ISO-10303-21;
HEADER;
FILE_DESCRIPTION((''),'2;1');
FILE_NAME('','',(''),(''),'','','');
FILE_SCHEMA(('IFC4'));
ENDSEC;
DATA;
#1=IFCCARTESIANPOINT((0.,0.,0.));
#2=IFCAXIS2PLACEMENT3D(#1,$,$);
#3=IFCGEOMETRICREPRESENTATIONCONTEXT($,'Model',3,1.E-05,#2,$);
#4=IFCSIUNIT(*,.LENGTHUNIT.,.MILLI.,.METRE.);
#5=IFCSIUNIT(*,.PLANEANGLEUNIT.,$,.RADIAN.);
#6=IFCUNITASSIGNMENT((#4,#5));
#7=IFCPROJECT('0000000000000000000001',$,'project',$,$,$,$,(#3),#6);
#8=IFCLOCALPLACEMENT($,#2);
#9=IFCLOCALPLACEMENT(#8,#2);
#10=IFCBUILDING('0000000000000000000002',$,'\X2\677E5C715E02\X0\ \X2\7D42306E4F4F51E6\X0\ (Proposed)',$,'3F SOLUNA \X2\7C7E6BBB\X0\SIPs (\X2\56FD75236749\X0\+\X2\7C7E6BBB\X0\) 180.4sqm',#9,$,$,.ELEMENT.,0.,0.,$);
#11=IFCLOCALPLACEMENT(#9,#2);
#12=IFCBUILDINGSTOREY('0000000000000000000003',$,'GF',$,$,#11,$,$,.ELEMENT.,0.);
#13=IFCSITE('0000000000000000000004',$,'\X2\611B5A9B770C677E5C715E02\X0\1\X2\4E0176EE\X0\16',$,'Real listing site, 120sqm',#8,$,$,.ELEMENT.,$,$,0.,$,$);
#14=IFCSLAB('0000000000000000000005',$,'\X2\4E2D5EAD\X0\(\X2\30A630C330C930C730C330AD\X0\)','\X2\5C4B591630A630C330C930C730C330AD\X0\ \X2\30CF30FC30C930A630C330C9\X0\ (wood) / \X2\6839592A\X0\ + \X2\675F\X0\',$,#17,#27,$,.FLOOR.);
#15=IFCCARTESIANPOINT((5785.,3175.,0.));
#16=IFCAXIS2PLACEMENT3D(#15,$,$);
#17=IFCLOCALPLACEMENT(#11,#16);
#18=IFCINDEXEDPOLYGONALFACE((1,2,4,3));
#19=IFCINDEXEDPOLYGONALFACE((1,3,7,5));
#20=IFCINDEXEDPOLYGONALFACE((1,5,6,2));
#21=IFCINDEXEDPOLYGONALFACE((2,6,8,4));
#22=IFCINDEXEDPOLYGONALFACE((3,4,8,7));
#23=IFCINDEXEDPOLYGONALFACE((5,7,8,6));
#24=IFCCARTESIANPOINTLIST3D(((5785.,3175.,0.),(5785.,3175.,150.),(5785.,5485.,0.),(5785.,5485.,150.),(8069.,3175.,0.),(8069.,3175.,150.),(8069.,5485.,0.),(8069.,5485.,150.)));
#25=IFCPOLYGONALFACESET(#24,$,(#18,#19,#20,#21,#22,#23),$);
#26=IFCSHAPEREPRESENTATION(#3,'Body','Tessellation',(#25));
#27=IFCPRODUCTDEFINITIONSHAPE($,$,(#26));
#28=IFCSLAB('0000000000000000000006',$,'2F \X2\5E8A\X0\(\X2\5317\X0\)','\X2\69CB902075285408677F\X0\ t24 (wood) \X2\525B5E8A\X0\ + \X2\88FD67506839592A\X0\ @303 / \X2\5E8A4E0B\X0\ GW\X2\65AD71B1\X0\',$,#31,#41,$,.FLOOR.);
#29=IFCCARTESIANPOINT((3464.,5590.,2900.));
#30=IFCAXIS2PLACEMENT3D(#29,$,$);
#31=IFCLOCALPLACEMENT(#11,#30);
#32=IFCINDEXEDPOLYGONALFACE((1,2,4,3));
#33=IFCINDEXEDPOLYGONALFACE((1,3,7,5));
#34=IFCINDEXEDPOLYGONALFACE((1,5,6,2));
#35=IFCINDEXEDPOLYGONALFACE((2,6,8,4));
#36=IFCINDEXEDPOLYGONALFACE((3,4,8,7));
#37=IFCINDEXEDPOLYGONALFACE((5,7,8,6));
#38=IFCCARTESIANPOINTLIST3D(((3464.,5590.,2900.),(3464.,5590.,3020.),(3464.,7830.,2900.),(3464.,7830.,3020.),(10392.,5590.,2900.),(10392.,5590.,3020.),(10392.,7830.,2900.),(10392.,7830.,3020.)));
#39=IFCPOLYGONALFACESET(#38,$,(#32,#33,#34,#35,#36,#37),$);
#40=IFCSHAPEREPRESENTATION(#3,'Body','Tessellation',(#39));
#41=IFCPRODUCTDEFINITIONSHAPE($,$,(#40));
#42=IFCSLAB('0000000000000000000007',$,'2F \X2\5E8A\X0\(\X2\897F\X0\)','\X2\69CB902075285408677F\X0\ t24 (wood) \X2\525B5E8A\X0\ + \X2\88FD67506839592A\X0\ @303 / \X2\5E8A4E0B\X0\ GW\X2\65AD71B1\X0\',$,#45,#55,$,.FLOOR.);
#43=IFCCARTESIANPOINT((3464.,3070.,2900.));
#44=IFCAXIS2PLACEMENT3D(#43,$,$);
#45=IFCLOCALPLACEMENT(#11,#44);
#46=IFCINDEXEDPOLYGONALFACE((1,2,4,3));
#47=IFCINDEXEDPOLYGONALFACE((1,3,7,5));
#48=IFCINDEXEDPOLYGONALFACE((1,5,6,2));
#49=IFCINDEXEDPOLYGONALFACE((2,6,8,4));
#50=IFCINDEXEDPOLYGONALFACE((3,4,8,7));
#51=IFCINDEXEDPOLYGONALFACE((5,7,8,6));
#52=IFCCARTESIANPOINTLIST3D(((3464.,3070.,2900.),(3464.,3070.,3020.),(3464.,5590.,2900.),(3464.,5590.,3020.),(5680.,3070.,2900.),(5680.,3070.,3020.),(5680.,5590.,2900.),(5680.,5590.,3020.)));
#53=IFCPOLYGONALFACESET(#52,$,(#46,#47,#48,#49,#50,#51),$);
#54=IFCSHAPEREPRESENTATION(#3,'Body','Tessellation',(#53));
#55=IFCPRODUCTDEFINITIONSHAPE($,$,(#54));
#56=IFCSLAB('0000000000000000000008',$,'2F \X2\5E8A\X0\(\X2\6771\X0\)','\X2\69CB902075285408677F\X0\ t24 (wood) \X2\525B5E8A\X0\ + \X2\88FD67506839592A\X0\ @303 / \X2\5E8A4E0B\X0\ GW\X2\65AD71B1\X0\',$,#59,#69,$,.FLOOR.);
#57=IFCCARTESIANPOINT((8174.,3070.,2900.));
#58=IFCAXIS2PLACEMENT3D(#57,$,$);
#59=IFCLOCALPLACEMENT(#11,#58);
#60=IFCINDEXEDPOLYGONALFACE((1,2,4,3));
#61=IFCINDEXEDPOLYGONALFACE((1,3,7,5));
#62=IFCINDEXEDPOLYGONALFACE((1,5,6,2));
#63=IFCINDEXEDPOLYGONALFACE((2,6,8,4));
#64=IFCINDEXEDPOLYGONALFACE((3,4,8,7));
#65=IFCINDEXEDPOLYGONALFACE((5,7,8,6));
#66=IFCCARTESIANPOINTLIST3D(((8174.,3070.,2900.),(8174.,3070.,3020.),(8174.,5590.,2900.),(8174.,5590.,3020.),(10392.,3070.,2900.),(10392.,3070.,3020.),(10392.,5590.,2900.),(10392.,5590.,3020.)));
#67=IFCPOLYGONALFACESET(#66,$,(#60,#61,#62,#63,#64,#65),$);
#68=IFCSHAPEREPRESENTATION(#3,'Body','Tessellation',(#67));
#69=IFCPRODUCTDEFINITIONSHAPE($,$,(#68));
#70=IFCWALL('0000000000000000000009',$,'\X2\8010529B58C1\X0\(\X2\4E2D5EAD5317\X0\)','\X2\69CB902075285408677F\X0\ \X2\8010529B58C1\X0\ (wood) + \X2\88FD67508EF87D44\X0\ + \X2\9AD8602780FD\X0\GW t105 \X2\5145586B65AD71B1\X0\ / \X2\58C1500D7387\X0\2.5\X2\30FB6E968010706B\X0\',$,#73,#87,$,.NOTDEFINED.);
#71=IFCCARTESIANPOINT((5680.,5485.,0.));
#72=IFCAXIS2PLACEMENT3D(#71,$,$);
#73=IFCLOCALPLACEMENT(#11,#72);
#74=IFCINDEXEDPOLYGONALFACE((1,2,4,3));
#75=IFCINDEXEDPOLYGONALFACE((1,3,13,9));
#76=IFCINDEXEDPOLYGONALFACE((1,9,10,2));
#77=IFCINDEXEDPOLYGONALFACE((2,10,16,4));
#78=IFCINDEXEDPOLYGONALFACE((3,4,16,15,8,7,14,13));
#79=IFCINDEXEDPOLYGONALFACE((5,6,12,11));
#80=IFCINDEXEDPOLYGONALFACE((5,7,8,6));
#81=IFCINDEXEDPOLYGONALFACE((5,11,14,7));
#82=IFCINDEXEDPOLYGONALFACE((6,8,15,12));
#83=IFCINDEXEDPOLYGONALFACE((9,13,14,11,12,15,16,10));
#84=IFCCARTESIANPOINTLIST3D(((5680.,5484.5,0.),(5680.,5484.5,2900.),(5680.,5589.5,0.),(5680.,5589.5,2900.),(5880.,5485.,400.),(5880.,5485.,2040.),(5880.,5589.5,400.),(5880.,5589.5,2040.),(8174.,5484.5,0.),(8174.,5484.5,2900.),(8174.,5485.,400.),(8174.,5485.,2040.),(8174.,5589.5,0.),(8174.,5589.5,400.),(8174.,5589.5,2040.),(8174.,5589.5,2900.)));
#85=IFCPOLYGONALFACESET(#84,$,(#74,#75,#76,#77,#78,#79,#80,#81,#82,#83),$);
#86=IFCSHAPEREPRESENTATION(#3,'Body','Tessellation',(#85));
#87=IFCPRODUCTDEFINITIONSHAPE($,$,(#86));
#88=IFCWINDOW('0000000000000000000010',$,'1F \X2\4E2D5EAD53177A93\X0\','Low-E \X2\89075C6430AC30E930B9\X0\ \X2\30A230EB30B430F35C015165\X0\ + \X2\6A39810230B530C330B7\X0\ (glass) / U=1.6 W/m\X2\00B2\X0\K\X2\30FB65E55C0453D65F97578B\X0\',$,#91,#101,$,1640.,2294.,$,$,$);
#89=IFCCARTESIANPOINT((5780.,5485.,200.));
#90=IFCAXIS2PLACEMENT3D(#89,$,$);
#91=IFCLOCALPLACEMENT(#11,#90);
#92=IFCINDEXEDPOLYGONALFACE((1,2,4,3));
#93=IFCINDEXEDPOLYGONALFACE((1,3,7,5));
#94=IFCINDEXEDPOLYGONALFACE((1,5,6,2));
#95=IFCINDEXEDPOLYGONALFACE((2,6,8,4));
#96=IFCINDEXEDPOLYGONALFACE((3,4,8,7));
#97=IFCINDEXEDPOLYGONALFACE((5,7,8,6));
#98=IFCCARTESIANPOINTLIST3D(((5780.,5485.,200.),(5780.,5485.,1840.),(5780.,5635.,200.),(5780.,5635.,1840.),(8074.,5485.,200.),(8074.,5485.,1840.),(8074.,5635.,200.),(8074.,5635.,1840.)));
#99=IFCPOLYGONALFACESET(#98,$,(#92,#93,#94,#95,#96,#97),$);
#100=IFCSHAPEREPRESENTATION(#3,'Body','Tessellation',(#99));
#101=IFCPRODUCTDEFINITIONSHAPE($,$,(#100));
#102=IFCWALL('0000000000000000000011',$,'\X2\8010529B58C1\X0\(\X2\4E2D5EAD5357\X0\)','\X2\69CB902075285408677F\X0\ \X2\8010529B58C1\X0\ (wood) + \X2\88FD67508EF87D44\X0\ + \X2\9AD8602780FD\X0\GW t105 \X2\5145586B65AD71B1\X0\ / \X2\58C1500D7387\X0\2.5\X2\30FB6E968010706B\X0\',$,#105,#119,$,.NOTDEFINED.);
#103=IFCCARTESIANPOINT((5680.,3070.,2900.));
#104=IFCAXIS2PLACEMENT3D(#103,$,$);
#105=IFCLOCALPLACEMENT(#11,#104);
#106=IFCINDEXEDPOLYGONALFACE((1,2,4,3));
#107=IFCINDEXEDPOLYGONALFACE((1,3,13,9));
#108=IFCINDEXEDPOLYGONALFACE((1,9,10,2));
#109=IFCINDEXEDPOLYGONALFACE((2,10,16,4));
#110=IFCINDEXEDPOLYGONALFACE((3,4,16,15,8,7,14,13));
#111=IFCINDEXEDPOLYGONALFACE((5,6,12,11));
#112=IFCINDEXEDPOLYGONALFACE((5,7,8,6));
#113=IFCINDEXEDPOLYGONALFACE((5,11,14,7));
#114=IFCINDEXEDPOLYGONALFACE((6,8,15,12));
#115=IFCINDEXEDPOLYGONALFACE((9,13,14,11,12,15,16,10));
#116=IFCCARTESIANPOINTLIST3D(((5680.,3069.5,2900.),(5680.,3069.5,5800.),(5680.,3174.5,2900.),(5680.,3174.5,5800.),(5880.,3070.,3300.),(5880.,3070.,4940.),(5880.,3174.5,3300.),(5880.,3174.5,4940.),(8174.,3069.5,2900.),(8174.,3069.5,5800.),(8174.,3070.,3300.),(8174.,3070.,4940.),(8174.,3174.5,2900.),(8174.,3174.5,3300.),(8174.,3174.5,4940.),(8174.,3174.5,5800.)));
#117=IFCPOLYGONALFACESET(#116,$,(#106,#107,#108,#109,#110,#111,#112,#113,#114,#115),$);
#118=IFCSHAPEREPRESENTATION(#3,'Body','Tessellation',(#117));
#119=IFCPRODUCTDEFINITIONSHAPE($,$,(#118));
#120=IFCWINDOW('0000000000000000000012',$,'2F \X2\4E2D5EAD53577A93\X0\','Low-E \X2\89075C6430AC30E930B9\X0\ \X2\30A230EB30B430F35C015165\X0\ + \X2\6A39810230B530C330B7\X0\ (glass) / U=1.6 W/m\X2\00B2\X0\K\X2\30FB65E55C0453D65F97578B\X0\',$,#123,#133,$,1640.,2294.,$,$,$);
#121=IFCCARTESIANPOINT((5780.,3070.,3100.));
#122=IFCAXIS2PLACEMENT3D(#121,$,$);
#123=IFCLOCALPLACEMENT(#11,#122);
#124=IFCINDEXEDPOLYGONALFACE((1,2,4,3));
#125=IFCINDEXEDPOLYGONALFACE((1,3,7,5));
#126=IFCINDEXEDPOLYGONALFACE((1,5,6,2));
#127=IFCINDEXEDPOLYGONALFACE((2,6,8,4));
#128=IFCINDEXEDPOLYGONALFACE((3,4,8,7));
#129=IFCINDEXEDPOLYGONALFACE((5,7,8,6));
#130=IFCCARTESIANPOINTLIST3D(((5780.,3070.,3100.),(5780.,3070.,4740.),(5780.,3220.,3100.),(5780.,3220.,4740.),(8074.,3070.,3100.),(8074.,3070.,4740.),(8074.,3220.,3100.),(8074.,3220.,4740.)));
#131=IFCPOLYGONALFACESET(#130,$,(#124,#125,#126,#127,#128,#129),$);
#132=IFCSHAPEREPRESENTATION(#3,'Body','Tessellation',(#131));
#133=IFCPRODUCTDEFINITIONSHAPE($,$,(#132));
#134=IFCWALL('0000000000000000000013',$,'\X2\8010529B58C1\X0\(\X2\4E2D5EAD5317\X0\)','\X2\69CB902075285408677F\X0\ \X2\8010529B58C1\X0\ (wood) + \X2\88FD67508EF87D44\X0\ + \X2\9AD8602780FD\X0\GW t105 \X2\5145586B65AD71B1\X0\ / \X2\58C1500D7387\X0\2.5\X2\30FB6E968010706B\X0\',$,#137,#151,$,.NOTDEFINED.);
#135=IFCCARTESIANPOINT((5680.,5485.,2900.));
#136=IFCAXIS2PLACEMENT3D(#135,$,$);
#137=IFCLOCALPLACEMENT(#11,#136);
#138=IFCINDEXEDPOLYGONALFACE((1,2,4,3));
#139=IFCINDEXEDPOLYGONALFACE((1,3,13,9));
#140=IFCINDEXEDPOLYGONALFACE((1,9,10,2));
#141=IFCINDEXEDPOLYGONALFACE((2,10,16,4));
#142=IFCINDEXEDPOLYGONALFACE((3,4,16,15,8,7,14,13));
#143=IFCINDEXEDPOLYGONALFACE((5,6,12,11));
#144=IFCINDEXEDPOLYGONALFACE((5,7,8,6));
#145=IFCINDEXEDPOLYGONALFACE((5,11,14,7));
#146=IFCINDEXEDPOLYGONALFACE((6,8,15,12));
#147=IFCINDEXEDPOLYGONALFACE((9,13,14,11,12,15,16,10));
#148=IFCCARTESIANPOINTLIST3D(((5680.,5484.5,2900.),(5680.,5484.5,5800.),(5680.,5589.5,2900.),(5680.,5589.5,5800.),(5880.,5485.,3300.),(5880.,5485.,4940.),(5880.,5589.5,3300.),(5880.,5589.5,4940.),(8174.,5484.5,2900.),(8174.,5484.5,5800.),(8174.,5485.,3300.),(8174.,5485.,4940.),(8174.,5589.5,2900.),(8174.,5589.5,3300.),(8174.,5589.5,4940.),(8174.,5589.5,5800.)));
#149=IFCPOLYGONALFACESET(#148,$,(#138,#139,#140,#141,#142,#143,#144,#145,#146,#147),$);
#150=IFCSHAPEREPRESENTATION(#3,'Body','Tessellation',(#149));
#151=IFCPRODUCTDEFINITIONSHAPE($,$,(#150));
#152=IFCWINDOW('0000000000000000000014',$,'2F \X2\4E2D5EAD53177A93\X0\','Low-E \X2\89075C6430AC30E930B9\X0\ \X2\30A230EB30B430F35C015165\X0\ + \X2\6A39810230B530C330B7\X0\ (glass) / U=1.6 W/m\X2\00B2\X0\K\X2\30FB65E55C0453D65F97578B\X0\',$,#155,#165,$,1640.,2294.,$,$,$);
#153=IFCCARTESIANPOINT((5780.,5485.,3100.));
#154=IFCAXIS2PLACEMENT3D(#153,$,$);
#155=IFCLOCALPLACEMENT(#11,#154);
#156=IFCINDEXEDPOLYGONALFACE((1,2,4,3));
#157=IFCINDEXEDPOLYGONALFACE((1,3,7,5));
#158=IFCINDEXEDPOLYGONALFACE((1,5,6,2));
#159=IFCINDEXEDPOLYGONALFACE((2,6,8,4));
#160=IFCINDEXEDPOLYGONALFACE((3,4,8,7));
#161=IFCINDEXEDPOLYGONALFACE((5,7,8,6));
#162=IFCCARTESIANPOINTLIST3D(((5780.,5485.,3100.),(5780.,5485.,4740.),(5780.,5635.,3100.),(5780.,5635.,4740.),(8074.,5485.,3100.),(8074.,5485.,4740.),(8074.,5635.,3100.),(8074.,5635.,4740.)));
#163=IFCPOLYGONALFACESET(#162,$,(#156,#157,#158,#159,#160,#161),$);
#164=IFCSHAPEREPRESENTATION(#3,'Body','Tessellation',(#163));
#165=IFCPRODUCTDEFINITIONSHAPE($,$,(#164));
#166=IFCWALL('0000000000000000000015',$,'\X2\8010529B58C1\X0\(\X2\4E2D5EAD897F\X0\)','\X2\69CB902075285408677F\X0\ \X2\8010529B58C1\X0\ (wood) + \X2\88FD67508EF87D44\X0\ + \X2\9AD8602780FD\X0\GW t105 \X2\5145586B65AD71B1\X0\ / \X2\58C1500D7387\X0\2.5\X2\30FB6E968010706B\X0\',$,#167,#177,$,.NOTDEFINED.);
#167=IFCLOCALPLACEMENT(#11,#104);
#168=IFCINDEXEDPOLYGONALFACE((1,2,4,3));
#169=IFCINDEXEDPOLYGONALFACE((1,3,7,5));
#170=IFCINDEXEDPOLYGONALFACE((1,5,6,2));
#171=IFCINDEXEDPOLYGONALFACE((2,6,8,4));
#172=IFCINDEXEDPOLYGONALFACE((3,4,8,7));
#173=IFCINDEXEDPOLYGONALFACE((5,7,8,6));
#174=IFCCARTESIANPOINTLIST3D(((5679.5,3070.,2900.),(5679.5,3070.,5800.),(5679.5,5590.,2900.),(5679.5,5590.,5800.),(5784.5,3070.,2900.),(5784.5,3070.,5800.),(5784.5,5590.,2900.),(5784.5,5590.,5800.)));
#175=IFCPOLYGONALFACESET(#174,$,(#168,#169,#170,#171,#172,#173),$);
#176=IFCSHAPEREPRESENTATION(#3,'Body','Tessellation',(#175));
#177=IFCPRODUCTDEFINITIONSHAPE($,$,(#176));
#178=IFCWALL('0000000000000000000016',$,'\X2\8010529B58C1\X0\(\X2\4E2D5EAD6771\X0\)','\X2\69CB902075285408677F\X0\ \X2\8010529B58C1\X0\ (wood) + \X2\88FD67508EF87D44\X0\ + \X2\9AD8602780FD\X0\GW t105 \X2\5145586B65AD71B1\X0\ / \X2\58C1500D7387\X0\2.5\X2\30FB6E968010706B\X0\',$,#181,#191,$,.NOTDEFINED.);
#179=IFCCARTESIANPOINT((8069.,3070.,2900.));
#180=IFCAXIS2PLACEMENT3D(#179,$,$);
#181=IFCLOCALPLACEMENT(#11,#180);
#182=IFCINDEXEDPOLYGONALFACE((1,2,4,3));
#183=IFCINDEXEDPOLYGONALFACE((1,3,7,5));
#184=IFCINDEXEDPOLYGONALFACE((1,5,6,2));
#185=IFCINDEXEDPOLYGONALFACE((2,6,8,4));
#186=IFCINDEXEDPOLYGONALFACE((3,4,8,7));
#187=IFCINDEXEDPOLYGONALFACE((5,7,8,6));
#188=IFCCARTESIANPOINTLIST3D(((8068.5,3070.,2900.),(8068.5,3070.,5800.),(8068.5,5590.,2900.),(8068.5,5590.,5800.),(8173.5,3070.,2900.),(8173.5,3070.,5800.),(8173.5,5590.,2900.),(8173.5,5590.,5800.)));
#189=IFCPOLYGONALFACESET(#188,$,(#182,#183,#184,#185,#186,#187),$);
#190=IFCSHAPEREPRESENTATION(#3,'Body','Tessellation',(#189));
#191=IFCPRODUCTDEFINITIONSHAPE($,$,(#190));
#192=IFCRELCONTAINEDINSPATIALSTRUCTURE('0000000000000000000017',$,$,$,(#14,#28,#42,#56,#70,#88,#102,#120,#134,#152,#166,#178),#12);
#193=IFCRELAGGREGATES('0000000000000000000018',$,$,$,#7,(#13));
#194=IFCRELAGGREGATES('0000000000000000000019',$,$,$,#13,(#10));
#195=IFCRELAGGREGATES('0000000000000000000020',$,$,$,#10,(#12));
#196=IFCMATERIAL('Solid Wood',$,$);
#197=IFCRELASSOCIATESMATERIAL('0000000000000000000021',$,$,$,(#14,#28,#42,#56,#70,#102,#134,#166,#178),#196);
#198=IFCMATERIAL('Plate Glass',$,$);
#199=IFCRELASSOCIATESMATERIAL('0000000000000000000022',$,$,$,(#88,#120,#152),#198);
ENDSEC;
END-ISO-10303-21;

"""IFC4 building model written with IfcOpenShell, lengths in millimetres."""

from ifc_helpers import new_model, si_unit, frame, frame_2d, origin, place, context, project, spatial, rectangle, extrude, material, element, fill, save


model = new_model("IFC4")

# Units and contexts
model_context = context("Model", 3, precision=1e-05, world=origin())
ifc_project = project(units=[si_unit("LENGTHUNIT", "METRE", prefix="MILLI"), si_unit("PLANEANGLEUNIT", "RADIAN")], contexts=[model_context])

# Site, building, storey
site_placement = place(None, origin())
site = spatial("IfcSite", under=ifc_project, at=site_placement, Name="愛媛県松山市1丁目16", ObjectType="Real listing site, 120sqm", CompositionType="ELEMENT", RefElevation=0.0)
building_placement = place(site_placement, origin())
building = spatial("IfcBuilding", under=site, at=building_placement, Name="松山市 終の住処 (Proposed)", ObjectType="3F SOLUNA 籾殻SIPs (国産杉+籾殻) 180.4sqm", CompositionType="ELEMENT", ElevationOfRefHeight=0.0, ElevationOfTerrain=0.0)
storey_placement = place(building_placement, origin())
storey = spatial("IfcBuildingStorey", under=building, at=storey_placement, Name="GF", CompositionType="ELEMENT", Elevation=0.0)

# Slabs
ifc_material_1 = material(Name="Solid Wood")
slab_1_placement = place(storey_placement, frame((5785.0, 3175.0, 0.0)))
element("IfcSlab", 1, at=slab_1_placement, inside=storey, material=ifc_material_1, Name="中庭(ウッドデッキ)", Description="屋外ウッドデッキ ハードウッド (wood) / 根太 + 束", PredefinedType="FLOOR", context=model_context, shape_type="SweptSolid", body=[
    extrude(rectangle(XDim=2284.0, YDim=2310.0, at=frame_2d((1142.0, 1155.0))), frame((5785.0, 3175.0, 0.0)), (0.0, 0.0, 1.0), 150.0),
])
slab_2_placement = place(storey_placement, frame((3464.0, 5590.0, 2900.0)))
element("IfcSlab", 2, at=slab_2_placement, inside=storey, material=ifc_material_1, Name="2F 床(北)", Description="構造用合板 t24 (wood) 剛床 + 製材根太 @303 / 床下 GW断熱", PredefinedType="FLOOR", context=model_context, shape_type="SweptSolid", body=[
    extrude(rectangle(XDim=6928.0, YDim=2240.0, at=frame_2d((3464.0, 1120.0))), frame((3464.0, 5590.0, 2900.0)), (0.0, 0.0, 1.0), 120.0),
])
slab_3_placement = place(storey_placement, frame((3464.0, 3070.0, 2900.0)))
element("IfcSlab", 3, at=slab_3_placement, inside=storey, material=ifc_material_1, Name="2F 床(西)", Description="構造用合板 t24 (wood) 剛床 + 製材根太 @303 / 床下 GW断熱", PredefinedType="FLOOR", context=model_context, shape_type="SweptSolid", body=[
    extrude(rectangle(XDim=2216.0, YDim=2520.0, at=frame_2d((1108.0, 1260.0))), frame((3464.0, 3070.0, 2900.0)), (0.0, 0.0, 1.0), 120.0),
])
slab_4_placement = place(storey_placement, frame((8174.0, 3070.0, 2900.0)))
element("IfcSlab", 4, at=slab_4_placement, inside=storey, material=ifc_material_1, Name="2F 床(東)", Description="構造用合板 t24 (wood) 剛床 + 製材根太 @303 / 床下 GW断熱", PredefinedType="FLOOR", context=model_context, shape_type="SweptSolid", body=[
    extrude(rectangle(XDim=2218.0, YDim=2520.0, at=frame_2d((1109.0, 1260.0))), frame((8174.0, 3070.0, 2900.0)), (0.0, 0.0, 1.0), 120.0),
])

# Wall, opening, window
wall_1_placement = place(storey_placement, frame((5680.0, 5485.0, 0.0)))
wall_1 = element("IfcWall", 5, at=wall_1_placement, inside=storey, material=ifc_material_1, Name="耐力壁(中庭北)", Description="構造用合板 耐力壁 (wood) + 製材軸組 + 高性能GW t105 充填断熱 / 壁倍率2.5・準耐火", PredefinedType="NOTDEFINED", context=model_context, shape_type="SweptSolid", body=[
    extrude(rectangle(XDim=2494.0, YDim=105.0, at=frame_2d((1247.0, 52.0))), frame((5680.0, 5485.0, 0.0)), (0.0, 0.0, 1.0), 2900.0),
])
opening_1_placement = place(storey_placement, frame((5780.0, 5485.0, 200.0)))
opening_1 = element("IfcOpeningElement", 6, at=opening_1_placement, cuts=wall_1, PredefinedType="NOTDEFINED", context=model_context, shape_type="SweptSolid", body=[
    extrude(rectangle(XDim=2294.0, YDim=150.0, at=frame_2d((1147.0, 75.0))), frame((5780.0, 5485.0, 200.0)), (0.0, 0.0, 1.0), 1640.0),
])
ifc_material_2 = material(Name="Plate Glass")
window_1_placement = place(storey_placement, frame((5780.0, 5485.0, 200.0)))
window_1 = element("IfcWindow", 7, at=window_1_placement, inside=storey, material=ifc_material_2, Name="1F 中庭北窓", Description="Low-E 複層ガラス アルゴン封入 + 樹脂サッシ (glass) / U=1.6 W/m²K・日射取得型", OverallHeight=1640.0, OverallWidth=2294.0, context=model_context, shape_type="SweptSolid", body=[
    extrude(rectangle(XDim=2294.0, YDim=150.0, at=frame_2d((1147.0, 75.0))), frame((5780.0, 5485.0, 200.0)), (0.0, 0.0, 1.0), 1640.0),
])
fill(opening_1, window_1)

# Walls, openings, windows
wall_2_placement = place(storey_placement, frame((5680.0, 3070.0, 2900.0)))
wall_2 = element("IfcWall", 8, at=wall_2_placement, inside=storey, material=ifc_material_1, Name="耐力壁(中庭南)", Description="構造用合板 耐力壁 (wood) + 製材軸組 + 高性能GW t105 充填断熱 / 壁倍率2.5・準耐火", PredefinedType="NOTDEFINED", context=model_context, shape_type="SweptSolid", body=[
    extrude(rectangle(XDim=2494.0, YDim=105.0, at=frame_2d((1247.0, 52.0))), frame((5680.0, 3070.0, 2900.0)), (0.0, 0.0, 1.0), 2900.0),
])
opening_2_placement = place(storey_placement, frame((5780.0, 3070.0, 3100.0)))
opening_2 = element("IfcOpeningElement", 9, at=opening_2_placement, cuts=wall_2, PredefinedType="NOTDEFINED", context=model_context, shape_type="SweptSolid", body=[
    extrude(rectangle(XDim=2294.0, YDim=150.0, at=frame_2d((1147.0, 75.0))), frame((5780.0, 3070.0, 3100.0)), (0.0, 0.0, 1.0), 1640.0),
])
window_2_placement = place(storey_placement, frame((5780.0, 3070.0, 3100.0)))
window_2 = element("IfcWindow", 10, at=window_2_placement, inside=storey, material=ifc_material_2, Name="2F 中庭南窓", Description="Low-E 複層ガラス アルゴン封入 + 樹脂サッシ (glass) / U=1.6 W/m²K・日射取得型", OverallHeight=1640.0, OverallWidth=2294.0, context=model_context, shape_type="SweptSolid", body=[
    extrude(rectangle(XDim=2294.0, YDim=150.0, at=frame_2d((1147.0, 75.0))), frame((5780.0, 3070.0, 3100.0)), (0.0, 0.0, 1.0), 1640.0),
])
fill(opening_2, window_2)
wall_3_placement = place(storey_placement, frame((5680.0, 5485.0, 2900.0)))
wall_3 = element("IfcWall", 11, at=wall_3_placement, inside=storey, material=ifc_material_1, Name="耐力壁(中庭北)", Description="構造用合板 耐力壁 (wood) + 製材軸組 + 高性能GW t105 充填断熱 / 壁倍率2.5・準耐火", PredefinedType="NOTDEFINED", context=model_context, shape_type="SweptSolid", body=[
    extrude(rectangle(XDim=2494.0, YDim=105.0, at=frame_2d((1247.0, 52.0))), frame((5680.0, 5485.0, 2900.0)), (0.0, 0.0, 1.0), 2900.0),
])
opening_3_placement = place(storey_placement, frame((5780.0, 5485.0, 3100.0)))
opening_3 = element("IfcOpeningElement", 12, at=opening_3_placement, cuts=wall_3, PredefinedType="NOTDEFINED", context=model_context, shape_type="SweptSolid", body=[
    extrude(rectangle(XDim=2294.0, YDim=150.0, at=frame_2d((1147.0, 75.0))), frame((5780.0, 5485.0, 3100.0)), (0.0, 0.0, 1.0), 1640.0),
])
window_3_placement = place(storey_placement, frame((5780.0, 5485.0, 3100.0)))
window_3 = element("IfcWindow", 13, at=window_3_placement, inside=storey, material=ifc_material_2, Name="2F 中庭北窓", Description="Low-E 複層ガラス アルゴン封入 + 樹脂サッシ (glass) / U=1.6 W/m²K・日射取得型", OverallHeight=1640.0, OverallWidth=2294.0, context=model_context, shape_type="SweptSolid", body=[
    extrude(rectangle(XDim=2294.0, YDim=150.0, at=frame_2d((1147.0, 75.0))), frame((5780.0, 5485.0, 3100.0)), (0.0, 0.0, 1.0), 1640.0),
])
fill(opening_3, window_3)

# Walls
wall_4_placement = place(storey_placement, frame((5680.0, 3070.0, 2900.0)))
element("IfcWall", 14, at=wall_4_placement, inside=storey, material=ifc_material_1, Name="耐力壁(中庭西)", Description="構造用合板 耐力壁 (wood) + 製材軸組 + 高性能GW t105 充填断熱 / 壁倍率2.5・準耐火", PredefinedType="NOTDEFINED", context=model_context, shape_type="SweptSolid", body=[
    extrude(rectangle(XDim=105.0, YDim=2520.0, at=frame_2d((52.0, 1260.0))), frame((5680.0, 3070.0, 2900.0)), (0.0, 0.0, 1.0), 2900.0),
])
wall_5_placement = place(storey_placement, frame((8069.0, 3070.0, 2900.0)))
element("IfcWall", 15, at=wall_5_placement, inside=storey, material=ifc_material_1, Name="耐力壁(中庭東)", Description="構造用合板 耐力壁 (wood) + 製材軸組 + 高性能GW t105 充填断熱 / 壁倍率2.5・準耐火", PredefinedType="NOTDEFINED", context=model_context, shape_type="SweptSolid", body=[
    extrude(rectangle(XDim=105.0, YDim=2520.0, at=frame_2d((52.0, 1260.0))), frame((8069.0, 3070.0, 2900.0)), (0.0, 0.0, 1.0), 2900.0),
])

save(model, "model.ifc")
